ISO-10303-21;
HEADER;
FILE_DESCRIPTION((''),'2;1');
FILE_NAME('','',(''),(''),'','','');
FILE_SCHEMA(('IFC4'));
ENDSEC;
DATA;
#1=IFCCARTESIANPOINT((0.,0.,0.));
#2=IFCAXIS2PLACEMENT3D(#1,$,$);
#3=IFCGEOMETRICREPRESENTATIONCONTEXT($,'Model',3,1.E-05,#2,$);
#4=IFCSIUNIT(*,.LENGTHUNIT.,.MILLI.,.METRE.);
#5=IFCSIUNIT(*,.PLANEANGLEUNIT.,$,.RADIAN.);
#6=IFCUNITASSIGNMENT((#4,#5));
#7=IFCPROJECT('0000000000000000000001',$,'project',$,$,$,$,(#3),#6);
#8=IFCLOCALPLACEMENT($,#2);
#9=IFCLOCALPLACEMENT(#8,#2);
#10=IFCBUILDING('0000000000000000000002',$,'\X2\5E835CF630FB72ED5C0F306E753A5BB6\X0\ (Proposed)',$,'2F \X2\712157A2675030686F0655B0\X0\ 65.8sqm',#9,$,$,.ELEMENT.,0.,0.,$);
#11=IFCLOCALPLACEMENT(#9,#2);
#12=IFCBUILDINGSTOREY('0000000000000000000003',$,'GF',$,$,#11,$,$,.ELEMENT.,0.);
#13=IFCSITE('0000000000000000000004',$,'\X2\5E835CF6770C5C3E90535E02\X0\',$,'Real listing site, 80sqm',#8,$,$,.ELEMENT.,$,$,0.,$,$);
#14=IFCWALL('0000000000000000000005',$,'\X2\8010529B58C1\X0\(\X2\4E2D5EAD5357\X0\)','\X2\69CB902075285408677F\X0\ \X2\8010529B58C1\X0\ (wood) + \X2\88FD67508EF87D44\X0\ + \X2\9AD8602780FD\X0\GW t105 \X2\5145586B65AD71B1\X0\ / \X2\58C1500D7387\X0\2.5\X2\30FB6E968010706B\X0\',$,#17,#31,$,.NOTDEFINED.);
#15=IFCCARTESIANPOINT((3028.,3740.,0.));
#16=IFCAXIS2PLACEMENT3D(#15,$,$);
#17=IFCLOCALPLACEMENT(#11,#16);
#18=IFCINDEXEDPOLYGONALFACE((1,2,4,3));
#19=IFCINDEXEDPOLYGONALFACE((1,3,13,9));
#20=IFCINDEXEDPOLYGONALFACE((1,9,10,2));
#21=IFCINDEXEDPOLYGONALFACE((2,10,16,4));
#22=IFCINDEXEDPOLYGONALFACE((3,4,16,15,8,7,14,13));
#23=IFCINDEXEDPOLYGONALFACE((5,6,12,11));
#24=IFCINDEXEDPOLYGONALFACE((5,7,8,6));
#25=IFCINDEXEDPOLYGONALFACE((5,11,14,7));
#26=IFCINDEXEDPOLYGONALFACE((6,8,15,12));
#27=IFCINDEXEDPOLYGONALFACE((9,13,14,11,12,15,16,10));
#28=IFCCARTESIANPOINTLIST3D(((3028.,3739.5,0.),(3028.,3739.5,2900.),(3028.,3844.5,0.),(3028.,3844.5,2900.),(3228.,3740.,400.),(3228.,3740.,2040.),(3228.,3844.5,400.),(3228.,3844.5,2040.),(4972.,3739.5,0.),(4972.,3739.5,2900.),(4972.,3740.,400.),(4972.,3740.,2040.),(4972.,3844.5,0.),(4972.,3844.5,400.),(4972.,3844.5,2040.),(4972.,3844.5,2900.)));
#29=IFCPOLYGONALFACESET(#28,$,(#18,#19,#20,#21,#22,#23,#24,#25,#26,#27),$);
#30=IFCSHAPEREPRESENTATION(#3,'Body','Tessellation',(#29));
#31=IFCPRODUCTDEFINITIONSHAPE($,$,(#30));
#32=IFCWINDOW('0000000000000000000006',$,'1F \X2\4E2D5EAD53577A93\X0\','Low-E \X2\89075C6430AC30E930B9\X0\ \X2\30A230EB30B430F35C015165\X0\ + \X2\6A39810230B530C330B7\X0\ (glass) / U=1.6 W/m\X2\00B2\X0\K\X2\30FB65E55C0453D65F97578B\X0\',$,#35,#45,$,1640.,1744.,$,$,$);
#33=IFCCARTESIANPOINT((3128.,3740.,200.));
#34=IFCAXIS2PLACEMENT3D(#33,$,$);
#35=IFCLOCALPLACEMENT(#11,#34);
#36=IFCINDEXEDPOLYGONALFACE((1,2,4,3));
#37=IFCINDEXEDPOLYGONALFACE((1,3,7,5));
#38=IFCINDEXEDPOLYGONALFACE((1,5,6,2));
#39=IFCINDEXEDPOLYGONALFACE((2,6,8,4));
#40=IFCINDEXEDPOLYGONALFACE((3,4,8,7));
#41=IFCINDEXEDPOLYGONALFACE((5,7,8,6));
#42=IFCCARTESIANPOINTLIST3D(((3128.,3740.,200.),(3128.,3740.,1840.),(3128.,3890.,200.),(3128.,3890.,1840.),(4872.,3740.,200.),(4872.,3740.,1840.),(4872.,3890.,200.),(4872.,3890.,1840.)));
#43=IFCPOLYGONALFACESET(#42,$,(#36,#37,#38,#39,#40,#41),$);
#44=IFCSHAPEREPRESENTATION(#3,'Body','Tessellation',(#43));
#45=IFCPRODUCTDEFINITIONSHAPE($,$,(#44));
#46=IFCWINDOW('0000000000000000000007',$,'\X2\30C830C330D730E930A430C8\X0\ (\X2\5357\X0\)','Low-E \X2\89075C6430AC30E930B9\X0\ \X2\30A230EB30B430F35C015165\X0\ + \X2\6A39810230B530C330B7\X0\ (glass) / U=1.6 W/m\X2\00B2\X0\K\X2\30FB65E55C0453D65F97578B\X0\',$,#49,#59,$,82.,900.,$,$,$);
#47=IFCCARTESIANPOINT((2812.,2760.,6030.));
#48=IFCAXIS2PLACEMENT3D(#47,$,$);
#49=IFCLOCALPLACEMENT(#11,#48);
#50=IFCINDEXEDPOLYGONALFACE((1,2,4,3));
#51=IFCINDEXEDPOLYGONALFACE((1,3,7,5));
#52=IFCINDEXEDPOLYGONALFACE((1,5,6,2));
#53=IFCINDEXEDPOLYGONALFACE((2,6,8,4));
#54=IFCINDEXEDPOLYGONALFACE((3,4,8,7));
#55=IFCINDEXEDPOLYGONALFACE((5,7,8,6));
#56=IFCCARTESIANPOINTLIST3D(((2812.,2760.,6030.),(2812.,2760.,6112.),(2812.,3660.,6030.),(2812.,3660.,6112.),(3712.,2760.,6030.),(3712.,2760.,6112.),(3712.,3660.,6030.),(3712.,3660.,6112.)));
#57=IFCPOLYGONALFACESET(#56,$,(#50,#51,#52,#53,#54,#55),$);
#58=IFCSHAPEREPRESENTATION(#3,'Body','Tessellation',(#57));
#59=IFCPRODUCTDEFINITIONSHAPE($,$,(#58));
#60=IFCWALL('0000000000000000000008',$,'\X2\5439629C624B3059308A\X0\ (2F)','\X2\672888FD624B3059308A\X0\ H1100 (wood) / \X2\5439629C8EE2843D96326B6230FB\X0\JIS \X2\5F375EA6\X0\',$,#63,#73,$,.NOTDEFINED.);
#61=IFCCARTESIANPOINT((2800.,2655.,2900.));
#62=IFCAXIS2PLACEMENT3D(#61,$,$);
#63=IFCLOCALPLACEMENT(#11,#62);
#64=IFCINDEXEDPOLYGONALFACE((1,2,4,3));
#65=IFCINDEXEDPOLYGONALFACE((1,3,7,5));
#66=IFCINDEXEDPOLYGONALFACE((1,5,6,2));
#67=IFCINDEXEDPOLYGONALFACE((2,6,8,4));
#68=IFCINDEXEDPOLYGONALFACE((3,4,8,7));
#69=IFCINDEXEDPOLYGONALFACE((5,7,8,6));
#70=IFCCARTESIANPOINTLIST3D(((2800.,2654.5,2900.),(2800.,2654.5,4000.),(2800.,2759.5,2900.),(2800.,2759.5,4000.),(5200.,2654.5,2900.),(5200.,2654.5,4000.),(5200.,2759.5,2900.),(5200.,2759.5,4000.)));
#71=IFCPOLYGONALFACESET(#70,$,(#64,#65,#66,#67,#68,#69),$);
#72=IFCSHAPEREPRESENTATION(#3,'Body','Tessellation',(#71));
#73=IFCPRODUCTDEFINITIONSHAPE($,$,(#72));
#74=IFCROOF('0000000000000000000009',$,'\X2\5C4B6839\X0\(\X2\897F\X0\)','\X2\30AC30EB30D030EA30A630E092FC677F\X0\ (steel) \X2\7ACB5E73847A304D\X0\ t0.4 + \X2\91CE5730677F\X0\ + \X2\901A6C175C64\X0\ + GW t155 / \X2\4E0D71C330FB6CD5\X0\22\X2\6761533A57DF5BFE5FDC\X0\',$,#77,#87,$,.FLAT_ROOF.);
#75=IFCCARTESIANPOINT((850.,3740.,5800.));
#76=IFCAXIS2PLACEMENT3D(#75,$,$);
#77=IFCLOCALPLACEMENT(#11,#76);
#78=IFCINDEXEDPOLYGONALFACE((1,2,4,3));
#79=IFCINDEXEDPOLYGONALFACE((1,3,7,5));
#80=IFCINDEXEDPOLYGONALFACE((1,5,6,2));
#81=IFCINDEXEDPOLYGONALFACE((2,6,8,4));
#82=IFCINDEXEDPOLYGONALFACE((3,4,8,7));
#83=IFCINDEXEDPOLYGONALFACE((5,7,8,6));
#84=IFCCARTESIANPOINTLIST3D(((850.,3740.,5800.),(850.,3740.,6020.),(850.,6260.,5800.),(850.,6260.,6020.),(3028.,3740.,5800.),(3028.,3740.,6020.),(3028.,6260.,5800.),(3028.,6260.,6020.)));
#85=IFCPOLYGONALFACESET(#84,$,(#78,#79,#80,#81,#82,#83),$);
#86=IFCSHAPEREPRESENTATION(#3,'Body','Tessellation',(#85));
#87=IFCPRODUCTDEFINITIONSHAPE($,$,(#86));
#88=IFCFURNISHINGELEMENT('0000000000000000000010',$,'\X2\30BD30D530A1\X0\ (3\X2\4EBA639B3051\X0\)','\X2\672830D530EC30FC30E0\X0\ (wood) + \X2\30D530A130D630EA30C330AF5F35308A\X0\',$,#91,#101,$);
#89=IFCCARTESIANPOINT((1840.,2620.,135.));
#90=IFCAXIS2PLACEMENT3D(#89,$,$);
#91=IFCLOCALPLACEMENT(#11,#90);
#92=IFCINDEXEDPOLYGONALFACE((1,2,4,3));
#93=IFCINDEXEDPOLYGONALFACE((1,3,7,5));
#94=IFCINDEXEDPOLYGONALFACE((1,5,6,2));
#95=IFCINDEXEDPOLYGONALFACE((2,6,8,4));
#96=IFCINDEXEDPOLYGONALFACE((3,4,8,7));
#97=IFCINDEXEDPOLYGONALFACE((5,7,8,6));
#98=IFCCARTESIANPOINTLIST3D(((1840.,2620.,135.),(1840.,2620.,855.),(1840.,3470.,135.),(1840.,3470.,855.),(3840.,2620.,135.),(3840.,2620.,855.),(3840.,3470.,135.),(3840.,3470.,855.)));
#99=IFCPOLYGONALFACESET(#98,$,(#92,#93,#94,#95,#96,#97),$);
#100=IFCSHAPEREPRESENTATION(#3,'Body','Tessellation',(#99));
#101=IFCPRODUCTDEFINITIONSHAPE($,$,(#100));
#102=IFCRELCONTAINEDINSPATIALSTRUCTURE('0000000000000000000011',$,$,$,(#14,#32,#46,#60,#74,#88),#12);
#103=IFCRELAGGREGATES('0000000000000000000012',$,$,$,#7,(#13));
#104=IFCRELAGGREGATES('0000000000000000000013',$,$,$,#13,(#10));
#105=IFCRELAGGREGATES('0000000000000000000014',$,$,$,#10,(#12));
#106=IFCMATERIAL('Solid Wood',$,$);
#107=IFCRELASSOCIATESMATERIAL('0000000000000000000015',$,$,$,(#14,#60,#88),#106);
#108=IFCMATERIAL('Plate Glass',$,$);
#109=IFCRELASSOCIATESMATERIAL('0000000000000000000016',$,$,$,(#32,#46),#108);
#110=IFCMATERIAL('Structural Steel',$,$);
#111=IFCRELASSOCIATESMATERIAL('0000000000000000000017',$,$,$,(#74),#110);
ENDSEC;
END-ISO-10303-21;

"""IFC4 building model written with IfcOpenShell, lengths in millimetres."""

from ifc_helpers import new_model, si_unit, frame, frame_2d, origin, place, context, project, spatial, rectangle, extrude, material, element, fill, save


model = new_model("IFC4")

# Units and contexts
model_context = context("Model", 3, precision=1e-05, world=origin())
ifc_project = project(units=[si_unit("LENGTHUNIT", "METRE", prefix="MILLI"), si_unit("PLANEANGLEUNIT", "RADIAN")], contexts=[model_context])

# Site, building, storey
site_placement = place(None, origin())
site = spatial("IfcSite", under=ifc_project, at=site_placement, Name="広島県尾道市", ObjectType="Real listing site, 80sqm", CompositionType="ELEMENT", RefElevation=0.0)
building_placement = place(site_placement, origin())
building = spatial("IfcBuilding", under=site, at=building_placement, Name="広島・狭小の町家 (Proposed)", ObjectType="2F 無垢材と漆喰 65.8sqm", CompositionType="ELEMENT", ElevationOfRefHeight=0.0, ElevationOfTerrain=0.0)
storey_placement = place(building_placement, origin())
storey = spatial("IfcBuildingStorey", under=building, at=storey_placement, Name="GF", CompositionType="ELEMENT", Elevation=0.0)

# Shared definitions
ifc_material_1 = material(Name="Solid Wood")

# Wall, opening, window
wall_1_placement = place(storey_placement, frame((3028.0, 3740.0, 0.0)))
wall_1 = element("IfcWall", 1, at=wall_1_placement, inside=storey, material=ifc_material_1, Name="耐力壁(中庭南)", Description="構造用合板 耐力壁 (wood) + 製材軸組 + 高性能GW t105 充填断熱 / 壁倍率2.5・準耐火", PredefinedType="NOTDEFINED", context=model_context, shape_type="SweptSolid", body=[
    extrude(rectangle(XDim=1944.0, YDim=105.0, at=frame_2d((972.0, 52.0))), frame((3028.0, 3740.0, 0.0)), (0.0, 0.0, 1.0), 2900.0),
])
opening_placement = place(storey_placement, frame((3128.0, 3740.0, 200.0)))
opening = element("IfcOpeningElement", 2, at=opening_placement, cuts=wall_1, PredefinedType="NOTDEFINED", context=model_context, shape_type="SweptSolid", body=[
    extrude(rectangle(XDim=1744.0, YDim=150.0, at=frame_2d((872.0, 75.0))), frame((3128.0, 3740.0, 200.0)), (0.0, 0.0, 1.0), 1640.0),
])
ifc_material_2 = material(Name="Plate Glass")
window_1_placement = place(storey_placement, frame((3128.0, 3740.0, 200.0)))
window_1 = element("IfcWindow", 3, at=window_1_placement, inside=storey, material=ifc_material_2, Name="1F 中庭南窓", Description="Low-E 複層ガラス アルゴン封入 + 樹脂サッシ (glass) / U=1.6 W/m²K・日射取得型", OverallHeight=1640.0, OverallWidth=1744.0, context=model_context, shape_type="SweptSolid", body=[
    extrude(rectangle(XDim=1744.0, YDim=150.0, at=frame_2d((872.0, 75.0))), frame((3128.0, 3740.0, 200.0)), (0.0, 0.0, 1.0), 1640.0),
])
fill(opening, window_1)

# Window
window_2_placement = place(storey_placement, frame((2812.0, 2760.0, 6030.0)))
element("IfcWindow", 4, at=window_2_placement, inside=storey, material=ifc_material_2, Name="トップライト (南)", Description="Low-E 複層ガラス アルゴン封入 + 樹脂サッシ (glass) / U=1.6 W/m²K・日射取得型", OverallHeight=82.0, OverallWidth=900.0, context=model_context, shape_type="SweptSolid", body=[
    extrude(rectangle(XDim=900.0, YDim=900.0, at=frame_2d((450.0, 450.0))), frame((2812.0, 2760.0, 6030.0)), (0.0, 0.0, 1.0), 82.0),
])

# Wall
wall_2_placement = place(storey_placement, frame((2800.0, 2655.0, 2900.0)))
element("IfcWall", 5, at=wall_2_placement, inside=storey, material=ifc_material_1, Name="吹抜手すり (2F)", Description="木製手すり H1100 (wood) / 吹抜転落防止・JIS 強度", PredefinedType="NOTDEFINED", context=model_context, shape_type="SweptSolid", body=[
    extrude(rectangle(XDim=2400.0, YDim=105.0, at=frame_2d((1200.0, 52.0))), frame((2800.0, 2655.0, 2900.0)), (0.0, 0.0, 1.0), 1100.0),
])

# Roof
ifc_material_3 = material(Name="Structural Steel")
for number, where, name in (
    (6, (850.0, 3740.0, 5800.0), "屋根(西)"),
):
    element("IfcRoof", number, at=place(storey_placement, frame(where)), inside=storey, material=ifc_material_3, Name=name, Description="ガルバリウム鋼板 (steel) 立平葺き t0.4 + 野地板 + 通気層 + GW t155 / 不燃・法22条区域対応", PredefinedType="FLAT_ROOF", context=model_context, shape_type="SweptSolid", body=[
        extrude(rectangle(XDim=2178.0, YDim=2520.0, at=frame_2d((1089.0, 1260.0))), frame((850.0, 3740.0, 5800.0)), (0.0, 0.0, 1.0), 220.0),
    ])

# Furnishing element
furnishing_placement = place(storey_placement, frame((1840.0, 2620.0, 135.0)))
element("IfcFurnishingElement", 7, at=furnishing_placement, inside=storey, material=ifc_material_1, Name="ソファ (3人掛け)", Description="木フレーム (wood) + ファブリック張り", context=model_context, shape_type="SweptSolid", body=[
    extrude(rectangle(XDim=2000.0, YDim=850.0, at=frame_2d((1000.0, 425.0))), frame((1840.0, 2620.0, 135.0)), (0.0, 0.0, 1.0), 720.0),
])

save(model, "model.ifc")
